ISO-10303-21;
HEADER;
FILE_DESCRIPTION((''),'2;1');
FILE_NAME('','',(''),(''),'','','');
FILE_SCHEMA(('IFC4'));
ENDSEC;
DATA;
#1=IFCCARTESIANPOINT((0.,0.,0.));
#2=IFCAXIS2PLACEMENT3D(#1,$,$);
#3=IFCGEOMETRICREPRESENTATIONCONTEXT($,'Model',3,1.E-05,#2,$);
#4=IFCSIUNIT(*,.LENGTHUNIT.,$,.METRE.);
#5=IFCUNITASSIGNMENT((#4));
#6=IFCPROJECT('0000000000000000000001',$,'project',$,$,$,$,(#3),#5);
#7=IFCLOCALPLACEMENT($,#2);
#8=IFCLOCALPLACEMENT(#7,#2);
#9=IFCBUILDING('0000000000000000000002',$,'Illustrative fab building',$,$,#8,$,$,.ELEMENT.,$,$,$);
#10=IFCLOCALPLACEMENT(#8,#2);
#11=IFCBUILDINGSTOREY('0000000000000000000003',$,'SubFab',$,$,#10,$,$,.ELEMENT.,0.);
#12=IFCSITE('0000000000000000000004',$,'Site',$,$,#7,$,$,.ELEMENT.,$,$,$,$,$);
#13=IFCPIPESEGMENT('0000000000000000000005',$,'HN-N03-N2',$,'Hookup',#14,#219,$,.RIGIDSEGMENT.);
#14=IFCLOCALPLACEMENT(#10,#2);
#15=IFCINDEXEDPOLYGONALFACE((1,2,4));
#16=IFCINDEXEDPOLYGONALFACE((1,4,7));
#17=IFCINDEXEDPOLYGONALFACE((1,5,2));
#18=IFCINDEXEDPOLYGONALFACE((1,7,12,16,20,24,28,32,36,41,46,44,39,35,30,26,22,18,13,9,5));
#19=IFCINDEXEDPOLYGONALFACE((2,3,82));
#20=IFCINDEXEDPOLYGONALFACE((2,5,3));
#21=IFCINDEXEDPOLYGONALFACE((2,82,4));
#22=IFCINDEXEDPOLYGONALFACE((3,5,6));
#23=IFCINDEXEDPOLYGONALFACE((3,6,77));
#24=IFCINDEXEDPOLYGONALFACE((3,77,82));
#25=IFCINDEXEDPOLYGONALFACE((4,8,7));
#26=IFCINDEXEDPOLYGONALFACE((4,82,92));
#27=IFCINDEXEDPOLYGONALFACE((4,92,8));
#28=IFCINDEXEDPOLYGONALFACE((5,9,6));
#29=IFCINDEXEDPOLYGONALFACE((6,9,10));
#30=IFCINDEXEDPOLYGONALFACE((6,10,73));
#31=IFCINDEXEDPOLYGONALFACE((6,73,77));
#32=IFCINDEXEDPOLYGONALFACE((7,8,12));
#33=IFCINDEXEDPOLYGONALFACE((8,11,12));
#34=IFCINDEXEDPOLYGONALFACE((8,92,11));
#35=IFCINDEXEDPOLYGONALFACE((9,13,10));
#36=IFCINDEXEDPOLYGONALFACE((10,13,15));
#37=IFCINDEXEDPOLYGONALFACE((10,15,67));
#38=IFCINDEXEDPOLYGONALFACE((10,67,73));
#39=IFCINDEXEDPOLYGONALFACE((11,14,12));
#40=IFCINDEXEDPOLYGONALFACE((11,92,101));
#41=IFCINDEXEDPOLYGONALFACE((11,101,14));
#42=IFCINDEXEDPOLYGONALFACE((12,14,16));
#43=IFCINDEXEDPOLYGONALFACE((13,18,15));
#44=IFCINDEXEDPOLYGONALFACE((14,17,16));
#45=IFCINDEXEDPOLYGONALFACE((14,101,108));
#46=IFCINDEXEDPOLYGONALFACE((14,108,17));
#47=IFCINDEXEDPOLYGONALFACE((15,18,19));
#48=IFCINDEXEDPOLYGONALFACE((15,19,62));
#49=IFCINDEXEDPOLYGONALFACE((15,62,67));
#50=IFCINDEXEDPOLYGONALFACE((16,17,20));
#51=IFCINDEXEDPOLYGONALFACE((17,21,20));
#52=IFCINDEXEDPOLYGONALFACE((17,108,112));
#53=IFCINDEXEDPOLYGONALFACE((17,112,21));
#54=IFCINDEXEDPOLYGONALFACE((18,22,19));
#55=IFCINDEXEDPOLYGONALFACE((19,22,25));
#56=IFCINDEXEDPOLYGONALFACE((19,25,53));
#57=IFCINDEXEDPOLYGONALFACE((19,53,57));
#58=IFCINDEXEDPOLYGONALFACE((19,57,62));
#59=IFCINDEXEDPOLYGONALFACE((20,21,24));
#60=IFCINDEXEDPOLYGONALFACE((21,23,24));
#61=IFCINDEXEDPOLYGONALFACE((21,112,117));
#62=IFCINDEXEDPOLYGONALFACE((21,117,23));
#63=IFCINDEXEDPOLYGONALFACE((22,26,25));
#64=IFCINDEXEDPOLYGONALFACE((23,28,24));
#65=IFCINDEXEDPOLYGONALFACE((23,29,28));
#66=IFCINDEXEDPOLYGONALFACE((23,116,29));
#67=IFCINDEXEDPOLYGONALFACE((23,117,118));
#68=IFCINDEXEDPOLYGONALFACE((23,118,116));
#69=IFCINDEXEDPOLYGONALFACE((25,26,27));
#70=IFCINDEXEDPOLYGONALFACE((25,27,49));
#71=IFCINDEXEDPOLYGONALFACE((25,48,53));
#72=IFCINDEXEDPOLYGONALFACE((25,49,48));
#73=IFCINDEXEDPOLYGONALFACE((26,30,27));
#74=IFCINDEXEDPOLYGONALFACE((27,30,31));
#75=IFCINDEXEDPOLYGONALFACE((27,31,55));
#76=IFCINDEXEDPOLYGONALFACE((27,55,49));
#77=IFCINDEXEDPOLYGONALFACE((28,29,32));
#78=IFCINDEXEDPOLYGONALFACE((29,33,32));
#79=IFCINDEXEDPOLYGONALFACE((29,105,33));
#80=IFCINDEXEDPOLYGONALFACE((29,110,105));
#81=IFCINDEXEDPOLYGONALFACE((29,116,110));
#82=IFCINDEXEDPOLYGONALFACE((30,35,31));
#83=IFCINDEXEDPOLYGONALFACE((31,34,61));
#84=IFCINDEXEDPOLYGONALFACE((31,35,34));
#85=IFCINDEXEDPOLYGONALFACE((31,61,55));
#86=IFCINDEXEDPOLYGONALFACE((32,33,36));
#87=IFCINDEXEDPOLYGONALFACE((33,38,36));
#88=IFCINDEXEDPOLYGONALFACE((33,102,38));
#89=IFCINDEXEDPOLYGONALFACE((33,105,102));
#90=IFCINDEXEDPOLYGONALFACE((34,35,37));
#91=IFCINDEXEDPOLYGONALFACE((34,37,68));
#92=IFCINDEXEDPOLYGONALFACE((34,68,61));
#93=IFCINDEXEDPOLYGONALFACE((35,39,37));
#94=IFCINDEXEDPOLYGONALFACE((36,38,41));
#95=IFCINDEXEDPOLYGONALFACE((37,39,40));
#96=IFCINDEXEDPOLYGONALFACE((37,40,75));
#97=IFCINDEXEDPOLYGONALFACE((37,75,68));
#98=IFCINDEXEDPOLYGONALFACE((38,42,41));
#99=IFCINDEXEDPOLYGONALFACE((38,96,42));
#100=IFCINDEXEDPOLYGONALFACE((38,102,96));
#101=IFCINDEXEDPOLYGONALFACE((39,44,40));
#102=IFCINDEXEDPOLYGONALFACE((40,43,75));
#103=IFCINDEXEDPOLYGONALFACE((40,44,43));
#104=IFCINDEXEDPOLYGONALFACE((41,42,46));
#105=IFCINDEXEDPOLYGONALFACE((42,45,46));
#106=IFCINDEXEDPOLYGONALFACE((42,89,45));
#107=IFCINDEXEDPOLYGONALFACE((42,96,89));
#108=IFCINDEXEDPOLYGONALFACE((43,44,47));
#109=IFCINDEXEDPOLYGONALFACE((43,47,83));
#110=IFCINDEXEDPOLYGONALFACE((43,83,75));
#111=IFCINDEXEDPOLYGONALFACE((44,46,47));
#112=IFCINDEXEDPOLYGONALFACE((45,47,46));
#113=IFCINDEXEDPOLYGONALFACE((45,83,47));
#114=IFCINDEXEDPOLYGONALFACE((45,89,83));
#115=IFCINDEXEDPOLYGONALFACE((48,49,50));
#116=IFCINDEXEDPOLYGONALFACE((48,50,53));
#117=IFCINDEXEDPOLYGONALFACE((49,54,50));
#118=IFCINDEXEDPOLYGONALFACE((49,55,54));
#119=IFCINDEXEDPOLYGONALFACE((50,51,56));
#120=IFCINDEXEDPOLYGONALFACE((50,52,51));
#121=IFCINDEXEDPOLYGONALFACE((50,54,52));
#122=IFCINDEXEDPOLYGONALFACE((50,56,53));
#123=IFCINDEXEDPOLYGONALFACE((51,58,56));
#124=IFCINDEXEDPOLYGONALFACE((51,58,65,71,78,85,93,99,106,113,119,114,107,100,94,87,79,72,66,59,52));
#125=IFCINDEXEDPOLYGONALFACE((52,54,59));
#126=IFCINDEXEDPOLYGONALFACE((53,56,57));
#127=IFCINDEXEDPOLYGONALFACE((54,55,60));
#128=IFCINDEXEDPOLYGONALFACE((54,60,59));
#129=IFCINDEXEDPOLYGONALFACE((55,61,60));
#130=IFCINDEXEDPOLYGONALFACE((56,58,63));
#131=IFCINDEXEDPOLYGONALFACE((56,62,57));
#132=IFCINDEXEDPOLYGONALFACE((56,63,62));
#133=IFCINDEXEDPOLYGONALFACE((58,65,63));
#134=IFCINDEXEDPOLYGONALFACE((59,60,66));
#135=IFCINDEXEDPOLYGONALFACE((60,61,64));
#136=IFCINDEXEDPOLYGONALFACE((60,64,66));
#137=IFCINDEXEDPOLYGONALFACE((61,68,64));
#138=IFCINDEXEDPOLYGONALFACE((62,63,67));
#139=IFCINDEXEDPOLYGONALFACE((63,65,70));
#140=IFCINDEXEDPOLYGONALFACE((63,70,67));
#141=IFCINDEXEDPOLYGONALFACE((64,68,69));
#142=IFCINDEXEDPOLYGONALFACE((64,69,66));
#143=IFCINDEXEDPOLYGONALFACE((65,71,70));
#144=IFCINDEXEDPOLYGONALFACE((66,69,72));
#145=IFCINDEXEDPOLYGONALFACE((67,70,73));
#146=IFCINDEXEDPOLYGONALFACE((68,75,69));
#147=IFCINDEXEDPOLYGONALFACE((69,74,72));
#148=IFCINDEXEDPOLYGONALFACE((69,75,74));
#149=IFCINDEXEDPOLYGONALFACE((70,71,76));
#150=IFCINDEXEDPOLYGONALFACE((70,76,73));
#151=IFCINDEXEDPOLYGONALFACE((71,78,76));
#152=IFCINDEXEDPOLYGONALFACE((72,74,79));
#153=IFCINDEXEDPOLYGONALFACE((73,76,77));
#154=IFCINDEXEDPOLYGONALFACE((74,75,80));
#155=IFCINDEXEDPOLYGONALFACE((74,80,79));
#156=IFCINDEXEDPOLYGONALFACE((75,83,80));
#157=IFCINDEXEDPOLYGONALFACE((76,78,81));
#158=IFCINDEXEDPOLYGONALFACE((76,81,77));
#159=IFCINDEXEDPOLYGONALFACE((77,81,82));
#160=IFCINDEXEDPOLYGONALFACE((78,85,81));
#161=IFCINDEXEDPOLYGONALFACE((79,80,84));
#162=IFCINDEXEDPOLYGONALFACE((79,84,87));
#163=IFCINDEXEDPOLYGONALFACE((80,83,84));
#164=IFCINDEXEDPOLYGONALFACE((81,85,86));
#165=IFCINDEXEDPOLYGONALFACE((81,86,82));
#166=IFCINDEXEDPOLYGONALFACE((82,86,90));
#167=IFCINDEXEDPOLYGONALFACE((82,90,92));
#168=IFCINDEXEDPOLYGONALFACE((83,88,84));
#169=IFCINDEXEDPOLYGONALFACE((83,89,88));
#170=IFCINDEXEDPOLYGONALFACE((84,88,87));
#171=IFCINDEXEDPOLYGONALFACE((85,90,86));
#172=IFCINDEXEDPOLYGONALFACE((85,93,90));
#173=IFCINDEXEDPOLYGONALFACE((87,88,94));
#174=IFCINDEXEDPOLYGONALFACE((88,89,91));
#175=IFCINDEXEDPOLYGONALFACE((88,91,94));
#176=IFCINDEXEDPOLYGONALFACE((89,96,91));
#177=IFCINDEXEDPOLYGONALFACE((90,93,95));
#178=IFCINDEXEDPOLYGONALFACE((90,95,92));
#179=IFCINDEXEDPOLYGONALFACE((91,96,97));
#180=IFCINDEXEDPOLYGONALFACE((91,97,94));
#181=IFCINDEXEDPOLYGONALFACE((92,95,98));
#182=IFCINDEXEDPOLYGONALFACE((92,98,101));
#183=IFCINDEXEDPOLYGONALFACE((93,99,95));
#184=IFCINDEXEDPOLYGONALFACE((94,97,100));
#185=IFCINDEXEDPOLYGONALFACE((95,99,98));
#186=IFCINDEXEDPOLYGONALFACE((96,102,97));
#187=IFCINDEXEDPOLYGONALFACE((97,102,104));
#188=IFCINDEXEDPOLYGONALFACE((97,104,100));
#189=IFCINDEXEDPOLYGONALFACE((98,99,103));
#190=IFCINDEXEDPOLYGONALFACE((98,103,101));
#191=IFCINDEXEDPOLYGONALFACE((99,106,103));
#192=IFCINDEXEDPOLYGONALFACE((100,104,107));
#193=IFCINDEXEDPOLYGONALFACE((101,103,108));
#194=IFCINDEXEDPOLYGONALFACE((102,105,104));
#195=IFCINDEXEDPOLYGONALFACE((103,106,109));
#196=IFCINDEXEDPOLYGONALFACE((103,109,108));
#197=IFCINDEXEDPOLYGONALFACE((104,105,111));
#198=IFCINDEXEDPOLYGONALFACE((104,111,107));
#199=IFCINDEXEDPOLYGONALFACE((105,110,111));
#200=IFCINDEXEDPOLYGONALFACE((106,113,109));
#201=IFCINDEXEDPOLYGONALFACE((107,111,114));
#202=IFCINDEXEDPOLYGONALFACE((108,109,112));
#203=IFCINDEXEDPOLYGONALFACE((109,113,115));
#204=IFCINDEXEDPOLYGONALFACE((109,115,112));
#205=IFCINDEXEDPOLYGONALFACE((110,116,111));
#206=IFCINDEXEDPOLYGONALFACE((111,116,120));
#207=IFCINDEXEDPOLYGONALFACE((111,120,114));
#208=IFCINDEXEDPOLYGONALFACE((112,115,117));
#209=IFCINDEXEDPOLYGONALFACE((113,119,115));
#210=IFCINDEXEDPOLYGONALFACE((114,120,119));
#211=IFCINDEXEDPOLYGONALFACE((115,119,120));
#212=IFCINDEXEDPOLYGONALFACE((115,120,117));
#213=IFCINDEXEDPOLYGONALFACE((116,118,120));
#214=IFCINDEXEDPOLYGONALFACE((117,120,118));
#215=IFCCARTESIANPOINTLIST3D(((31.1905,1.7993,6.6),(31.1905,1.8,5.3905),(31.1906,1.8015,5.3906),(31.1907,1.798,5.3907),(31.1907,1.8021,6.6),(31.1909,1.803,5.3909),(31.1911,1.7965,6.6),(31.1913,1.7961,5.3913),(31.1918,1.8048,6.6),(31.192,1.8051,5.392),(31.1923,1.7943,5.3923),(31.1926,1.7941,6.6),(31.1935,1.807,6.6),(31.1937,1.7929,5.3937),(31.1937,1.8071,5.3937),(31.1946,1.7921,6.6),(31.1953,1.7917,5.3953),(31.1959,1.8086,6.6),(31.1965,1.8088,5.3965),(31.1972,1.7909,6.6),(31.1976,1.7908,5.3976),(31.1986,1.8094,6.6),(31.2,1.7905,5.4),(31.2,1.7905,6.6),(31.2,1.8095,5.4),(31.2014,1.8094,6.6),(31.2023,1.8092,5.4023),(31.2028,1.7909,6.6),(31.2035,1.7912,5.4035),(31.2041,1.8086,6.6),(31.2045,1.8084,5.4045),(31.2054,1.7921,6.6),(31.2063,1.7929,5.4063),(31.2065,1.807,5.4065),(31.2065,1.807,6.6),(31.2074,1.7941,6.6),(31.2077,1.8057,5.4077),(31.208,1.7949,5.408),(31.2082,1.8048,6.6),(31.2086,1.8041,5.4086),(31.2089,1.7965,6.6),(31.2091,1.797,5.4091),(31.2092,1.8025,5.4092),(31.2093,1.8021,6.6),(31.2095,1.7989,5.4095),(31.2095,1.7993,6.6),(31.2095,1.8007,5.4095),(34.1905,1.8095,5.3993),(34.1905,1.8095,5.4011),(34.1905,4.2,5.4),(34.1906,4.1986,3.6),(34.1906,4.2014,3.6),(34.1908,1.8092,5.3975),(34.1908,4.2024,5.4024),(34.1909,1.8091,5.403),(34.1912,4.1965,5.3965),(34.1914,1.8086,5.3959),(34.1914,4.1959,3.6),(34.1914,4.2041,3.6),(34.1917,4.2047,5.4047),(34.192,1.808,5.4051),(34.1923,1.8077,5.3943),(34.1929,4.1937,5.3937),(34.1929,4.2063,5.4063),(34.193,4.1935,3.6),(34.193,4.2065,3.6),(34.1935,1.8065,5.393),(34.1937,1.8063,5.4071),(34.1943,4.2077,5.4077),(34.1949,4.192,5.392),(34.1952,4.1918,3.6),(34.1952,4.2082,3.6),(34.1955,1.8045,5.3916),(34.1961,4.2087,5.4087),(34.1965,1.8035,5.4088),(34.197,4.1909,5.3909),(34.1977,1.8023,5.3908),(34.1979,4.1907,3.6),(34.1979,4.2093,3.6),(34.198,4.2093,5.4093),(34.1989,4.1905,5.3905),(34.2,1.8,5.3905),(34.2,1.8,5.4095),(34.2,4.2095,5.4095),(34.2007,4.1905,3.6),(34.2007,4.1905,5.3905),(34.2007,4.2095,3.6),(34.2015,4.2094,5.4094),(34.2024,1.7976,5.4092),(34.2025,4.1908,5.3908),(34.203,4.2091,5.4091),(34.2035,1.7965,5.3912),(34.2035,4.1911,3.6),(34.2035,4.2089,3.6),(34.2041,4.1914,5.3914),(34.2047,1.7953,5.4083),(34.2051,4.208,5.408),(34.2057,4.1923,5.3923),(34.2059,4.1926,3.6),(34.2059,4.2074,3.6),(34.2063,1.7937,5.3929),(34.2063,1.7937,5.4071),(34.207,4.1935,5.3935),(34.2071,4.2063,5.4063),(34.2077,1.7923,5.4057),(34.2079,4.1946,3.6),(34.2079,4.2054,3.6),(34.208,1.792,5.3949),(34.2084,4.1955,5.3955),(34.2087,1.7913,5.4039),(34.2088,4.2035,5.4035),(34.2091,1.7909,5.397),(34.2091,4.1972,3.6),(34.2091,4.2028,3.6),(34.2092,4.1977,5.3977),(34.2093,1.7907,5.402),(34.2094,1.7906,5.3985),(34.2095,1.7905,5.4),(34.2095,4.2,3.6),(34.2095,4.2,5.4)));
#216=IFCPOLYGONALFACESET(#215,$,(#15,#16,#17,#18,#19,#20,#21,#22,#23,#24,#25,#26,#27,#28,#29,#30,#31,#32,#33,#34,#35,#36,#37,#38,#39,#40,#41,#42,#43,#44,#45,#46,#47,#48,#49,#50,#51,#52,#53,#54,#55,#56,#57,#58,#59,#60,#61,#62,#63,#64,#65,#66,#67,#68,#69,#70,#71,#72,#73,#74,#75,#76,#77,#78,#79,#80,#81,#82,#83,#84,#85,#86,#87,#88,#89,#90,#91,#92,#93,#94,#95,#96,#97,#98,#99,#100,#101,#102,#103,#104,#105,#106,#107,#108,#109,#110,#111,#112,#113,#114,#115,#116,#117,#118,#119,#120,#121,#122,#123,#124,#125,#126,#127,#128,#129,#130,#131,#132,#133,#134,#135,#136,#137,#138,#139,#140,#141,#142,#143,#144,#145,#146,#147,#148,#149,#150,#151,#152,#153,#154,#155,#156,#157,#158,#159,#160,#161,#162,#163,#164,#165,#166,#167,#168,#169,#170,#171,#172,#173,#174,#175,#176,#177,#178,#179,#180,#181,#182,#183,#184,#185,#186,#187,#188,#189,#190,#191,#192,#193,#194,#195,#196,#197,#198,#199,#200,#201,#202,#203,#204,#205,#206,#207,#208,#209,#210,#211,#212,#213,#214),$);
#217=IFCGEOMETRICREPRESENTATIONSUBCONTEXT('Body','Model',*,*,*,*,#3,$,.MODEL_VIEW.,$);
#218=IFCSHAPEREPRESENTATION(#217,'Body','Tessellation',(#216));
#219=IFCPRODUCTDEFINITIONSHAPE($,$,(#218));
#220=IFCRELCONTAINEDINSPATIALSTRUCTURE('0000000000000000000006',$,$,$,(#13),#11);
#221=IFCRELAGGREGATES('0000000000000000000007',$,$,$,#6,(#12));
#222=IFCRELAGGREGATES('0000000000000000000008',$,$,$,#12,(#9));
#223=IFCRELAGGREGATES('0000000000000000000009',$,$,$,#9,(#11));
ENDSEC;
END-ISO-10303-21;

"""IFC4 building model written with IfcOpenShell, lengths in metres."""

from ifc_helpers import new_model, entity, si_unit, origin, place, context, subcontext, project, spatial, element, save


model = new_model("IFC4")

# Units and contexts
model_context = context("Model", 3, precision=1e-05, world=origin())
body_context = subcontext(model_context, "Body", "Model", "MODEL_VIEW")
ifc_project = project(units=[si_unit("LENGTHUNIT", "METRE")], contexts=[model_context])

# Site, building, storey
site_placement = place(None, origin())
site = spatial("IfcSite", under=ifc_project, at=site_placement, Name="Site", CompositionType="ELEMENT")
building_placement = place(site_placement, origin())
building = spatial("IfcBuilding", under=site, at=building_placement, Name="Illustrative fab building", CompositionType="ELEMENT")
storey_placement = place(building_placement, origin())
storey = spatial("IfcBuildingStorey", under=building, at=storey_placement, Name="SubFab", CompositionType="ELEMENT", Elevation=0.0)

# Pipe segment
pipe_segment_1_placement = place(storey_placement, origin())
element("IfcPipeSegment", 1, at=pipe_segment_1_placement, inside=storey, Name="HN-N03-N2", ObjectType="Hookup", PredefinedType="RIGIDSEGMENT", context=body_context, shape_type="AdvancedSweptSolid", body=[
    entity("IfcSweptDiskSolid", entity("IfcPolyline", [entity("IfcCartesianPoint", [34.2, 4.2, 3.6]), entity("IfcCartesianPoint", [34.2, 4.2, 5.4]), entity("IfcCartesianPoint", [34.2, 1.8, 5.4]), entity("IfcCartesianPoint", [31.2, 1.8, 5.4]), entity("IfcCartesianPoint", [31.2, 1.8, 6.6])]), 0.0095),
])

save(model, "model.ifc")
